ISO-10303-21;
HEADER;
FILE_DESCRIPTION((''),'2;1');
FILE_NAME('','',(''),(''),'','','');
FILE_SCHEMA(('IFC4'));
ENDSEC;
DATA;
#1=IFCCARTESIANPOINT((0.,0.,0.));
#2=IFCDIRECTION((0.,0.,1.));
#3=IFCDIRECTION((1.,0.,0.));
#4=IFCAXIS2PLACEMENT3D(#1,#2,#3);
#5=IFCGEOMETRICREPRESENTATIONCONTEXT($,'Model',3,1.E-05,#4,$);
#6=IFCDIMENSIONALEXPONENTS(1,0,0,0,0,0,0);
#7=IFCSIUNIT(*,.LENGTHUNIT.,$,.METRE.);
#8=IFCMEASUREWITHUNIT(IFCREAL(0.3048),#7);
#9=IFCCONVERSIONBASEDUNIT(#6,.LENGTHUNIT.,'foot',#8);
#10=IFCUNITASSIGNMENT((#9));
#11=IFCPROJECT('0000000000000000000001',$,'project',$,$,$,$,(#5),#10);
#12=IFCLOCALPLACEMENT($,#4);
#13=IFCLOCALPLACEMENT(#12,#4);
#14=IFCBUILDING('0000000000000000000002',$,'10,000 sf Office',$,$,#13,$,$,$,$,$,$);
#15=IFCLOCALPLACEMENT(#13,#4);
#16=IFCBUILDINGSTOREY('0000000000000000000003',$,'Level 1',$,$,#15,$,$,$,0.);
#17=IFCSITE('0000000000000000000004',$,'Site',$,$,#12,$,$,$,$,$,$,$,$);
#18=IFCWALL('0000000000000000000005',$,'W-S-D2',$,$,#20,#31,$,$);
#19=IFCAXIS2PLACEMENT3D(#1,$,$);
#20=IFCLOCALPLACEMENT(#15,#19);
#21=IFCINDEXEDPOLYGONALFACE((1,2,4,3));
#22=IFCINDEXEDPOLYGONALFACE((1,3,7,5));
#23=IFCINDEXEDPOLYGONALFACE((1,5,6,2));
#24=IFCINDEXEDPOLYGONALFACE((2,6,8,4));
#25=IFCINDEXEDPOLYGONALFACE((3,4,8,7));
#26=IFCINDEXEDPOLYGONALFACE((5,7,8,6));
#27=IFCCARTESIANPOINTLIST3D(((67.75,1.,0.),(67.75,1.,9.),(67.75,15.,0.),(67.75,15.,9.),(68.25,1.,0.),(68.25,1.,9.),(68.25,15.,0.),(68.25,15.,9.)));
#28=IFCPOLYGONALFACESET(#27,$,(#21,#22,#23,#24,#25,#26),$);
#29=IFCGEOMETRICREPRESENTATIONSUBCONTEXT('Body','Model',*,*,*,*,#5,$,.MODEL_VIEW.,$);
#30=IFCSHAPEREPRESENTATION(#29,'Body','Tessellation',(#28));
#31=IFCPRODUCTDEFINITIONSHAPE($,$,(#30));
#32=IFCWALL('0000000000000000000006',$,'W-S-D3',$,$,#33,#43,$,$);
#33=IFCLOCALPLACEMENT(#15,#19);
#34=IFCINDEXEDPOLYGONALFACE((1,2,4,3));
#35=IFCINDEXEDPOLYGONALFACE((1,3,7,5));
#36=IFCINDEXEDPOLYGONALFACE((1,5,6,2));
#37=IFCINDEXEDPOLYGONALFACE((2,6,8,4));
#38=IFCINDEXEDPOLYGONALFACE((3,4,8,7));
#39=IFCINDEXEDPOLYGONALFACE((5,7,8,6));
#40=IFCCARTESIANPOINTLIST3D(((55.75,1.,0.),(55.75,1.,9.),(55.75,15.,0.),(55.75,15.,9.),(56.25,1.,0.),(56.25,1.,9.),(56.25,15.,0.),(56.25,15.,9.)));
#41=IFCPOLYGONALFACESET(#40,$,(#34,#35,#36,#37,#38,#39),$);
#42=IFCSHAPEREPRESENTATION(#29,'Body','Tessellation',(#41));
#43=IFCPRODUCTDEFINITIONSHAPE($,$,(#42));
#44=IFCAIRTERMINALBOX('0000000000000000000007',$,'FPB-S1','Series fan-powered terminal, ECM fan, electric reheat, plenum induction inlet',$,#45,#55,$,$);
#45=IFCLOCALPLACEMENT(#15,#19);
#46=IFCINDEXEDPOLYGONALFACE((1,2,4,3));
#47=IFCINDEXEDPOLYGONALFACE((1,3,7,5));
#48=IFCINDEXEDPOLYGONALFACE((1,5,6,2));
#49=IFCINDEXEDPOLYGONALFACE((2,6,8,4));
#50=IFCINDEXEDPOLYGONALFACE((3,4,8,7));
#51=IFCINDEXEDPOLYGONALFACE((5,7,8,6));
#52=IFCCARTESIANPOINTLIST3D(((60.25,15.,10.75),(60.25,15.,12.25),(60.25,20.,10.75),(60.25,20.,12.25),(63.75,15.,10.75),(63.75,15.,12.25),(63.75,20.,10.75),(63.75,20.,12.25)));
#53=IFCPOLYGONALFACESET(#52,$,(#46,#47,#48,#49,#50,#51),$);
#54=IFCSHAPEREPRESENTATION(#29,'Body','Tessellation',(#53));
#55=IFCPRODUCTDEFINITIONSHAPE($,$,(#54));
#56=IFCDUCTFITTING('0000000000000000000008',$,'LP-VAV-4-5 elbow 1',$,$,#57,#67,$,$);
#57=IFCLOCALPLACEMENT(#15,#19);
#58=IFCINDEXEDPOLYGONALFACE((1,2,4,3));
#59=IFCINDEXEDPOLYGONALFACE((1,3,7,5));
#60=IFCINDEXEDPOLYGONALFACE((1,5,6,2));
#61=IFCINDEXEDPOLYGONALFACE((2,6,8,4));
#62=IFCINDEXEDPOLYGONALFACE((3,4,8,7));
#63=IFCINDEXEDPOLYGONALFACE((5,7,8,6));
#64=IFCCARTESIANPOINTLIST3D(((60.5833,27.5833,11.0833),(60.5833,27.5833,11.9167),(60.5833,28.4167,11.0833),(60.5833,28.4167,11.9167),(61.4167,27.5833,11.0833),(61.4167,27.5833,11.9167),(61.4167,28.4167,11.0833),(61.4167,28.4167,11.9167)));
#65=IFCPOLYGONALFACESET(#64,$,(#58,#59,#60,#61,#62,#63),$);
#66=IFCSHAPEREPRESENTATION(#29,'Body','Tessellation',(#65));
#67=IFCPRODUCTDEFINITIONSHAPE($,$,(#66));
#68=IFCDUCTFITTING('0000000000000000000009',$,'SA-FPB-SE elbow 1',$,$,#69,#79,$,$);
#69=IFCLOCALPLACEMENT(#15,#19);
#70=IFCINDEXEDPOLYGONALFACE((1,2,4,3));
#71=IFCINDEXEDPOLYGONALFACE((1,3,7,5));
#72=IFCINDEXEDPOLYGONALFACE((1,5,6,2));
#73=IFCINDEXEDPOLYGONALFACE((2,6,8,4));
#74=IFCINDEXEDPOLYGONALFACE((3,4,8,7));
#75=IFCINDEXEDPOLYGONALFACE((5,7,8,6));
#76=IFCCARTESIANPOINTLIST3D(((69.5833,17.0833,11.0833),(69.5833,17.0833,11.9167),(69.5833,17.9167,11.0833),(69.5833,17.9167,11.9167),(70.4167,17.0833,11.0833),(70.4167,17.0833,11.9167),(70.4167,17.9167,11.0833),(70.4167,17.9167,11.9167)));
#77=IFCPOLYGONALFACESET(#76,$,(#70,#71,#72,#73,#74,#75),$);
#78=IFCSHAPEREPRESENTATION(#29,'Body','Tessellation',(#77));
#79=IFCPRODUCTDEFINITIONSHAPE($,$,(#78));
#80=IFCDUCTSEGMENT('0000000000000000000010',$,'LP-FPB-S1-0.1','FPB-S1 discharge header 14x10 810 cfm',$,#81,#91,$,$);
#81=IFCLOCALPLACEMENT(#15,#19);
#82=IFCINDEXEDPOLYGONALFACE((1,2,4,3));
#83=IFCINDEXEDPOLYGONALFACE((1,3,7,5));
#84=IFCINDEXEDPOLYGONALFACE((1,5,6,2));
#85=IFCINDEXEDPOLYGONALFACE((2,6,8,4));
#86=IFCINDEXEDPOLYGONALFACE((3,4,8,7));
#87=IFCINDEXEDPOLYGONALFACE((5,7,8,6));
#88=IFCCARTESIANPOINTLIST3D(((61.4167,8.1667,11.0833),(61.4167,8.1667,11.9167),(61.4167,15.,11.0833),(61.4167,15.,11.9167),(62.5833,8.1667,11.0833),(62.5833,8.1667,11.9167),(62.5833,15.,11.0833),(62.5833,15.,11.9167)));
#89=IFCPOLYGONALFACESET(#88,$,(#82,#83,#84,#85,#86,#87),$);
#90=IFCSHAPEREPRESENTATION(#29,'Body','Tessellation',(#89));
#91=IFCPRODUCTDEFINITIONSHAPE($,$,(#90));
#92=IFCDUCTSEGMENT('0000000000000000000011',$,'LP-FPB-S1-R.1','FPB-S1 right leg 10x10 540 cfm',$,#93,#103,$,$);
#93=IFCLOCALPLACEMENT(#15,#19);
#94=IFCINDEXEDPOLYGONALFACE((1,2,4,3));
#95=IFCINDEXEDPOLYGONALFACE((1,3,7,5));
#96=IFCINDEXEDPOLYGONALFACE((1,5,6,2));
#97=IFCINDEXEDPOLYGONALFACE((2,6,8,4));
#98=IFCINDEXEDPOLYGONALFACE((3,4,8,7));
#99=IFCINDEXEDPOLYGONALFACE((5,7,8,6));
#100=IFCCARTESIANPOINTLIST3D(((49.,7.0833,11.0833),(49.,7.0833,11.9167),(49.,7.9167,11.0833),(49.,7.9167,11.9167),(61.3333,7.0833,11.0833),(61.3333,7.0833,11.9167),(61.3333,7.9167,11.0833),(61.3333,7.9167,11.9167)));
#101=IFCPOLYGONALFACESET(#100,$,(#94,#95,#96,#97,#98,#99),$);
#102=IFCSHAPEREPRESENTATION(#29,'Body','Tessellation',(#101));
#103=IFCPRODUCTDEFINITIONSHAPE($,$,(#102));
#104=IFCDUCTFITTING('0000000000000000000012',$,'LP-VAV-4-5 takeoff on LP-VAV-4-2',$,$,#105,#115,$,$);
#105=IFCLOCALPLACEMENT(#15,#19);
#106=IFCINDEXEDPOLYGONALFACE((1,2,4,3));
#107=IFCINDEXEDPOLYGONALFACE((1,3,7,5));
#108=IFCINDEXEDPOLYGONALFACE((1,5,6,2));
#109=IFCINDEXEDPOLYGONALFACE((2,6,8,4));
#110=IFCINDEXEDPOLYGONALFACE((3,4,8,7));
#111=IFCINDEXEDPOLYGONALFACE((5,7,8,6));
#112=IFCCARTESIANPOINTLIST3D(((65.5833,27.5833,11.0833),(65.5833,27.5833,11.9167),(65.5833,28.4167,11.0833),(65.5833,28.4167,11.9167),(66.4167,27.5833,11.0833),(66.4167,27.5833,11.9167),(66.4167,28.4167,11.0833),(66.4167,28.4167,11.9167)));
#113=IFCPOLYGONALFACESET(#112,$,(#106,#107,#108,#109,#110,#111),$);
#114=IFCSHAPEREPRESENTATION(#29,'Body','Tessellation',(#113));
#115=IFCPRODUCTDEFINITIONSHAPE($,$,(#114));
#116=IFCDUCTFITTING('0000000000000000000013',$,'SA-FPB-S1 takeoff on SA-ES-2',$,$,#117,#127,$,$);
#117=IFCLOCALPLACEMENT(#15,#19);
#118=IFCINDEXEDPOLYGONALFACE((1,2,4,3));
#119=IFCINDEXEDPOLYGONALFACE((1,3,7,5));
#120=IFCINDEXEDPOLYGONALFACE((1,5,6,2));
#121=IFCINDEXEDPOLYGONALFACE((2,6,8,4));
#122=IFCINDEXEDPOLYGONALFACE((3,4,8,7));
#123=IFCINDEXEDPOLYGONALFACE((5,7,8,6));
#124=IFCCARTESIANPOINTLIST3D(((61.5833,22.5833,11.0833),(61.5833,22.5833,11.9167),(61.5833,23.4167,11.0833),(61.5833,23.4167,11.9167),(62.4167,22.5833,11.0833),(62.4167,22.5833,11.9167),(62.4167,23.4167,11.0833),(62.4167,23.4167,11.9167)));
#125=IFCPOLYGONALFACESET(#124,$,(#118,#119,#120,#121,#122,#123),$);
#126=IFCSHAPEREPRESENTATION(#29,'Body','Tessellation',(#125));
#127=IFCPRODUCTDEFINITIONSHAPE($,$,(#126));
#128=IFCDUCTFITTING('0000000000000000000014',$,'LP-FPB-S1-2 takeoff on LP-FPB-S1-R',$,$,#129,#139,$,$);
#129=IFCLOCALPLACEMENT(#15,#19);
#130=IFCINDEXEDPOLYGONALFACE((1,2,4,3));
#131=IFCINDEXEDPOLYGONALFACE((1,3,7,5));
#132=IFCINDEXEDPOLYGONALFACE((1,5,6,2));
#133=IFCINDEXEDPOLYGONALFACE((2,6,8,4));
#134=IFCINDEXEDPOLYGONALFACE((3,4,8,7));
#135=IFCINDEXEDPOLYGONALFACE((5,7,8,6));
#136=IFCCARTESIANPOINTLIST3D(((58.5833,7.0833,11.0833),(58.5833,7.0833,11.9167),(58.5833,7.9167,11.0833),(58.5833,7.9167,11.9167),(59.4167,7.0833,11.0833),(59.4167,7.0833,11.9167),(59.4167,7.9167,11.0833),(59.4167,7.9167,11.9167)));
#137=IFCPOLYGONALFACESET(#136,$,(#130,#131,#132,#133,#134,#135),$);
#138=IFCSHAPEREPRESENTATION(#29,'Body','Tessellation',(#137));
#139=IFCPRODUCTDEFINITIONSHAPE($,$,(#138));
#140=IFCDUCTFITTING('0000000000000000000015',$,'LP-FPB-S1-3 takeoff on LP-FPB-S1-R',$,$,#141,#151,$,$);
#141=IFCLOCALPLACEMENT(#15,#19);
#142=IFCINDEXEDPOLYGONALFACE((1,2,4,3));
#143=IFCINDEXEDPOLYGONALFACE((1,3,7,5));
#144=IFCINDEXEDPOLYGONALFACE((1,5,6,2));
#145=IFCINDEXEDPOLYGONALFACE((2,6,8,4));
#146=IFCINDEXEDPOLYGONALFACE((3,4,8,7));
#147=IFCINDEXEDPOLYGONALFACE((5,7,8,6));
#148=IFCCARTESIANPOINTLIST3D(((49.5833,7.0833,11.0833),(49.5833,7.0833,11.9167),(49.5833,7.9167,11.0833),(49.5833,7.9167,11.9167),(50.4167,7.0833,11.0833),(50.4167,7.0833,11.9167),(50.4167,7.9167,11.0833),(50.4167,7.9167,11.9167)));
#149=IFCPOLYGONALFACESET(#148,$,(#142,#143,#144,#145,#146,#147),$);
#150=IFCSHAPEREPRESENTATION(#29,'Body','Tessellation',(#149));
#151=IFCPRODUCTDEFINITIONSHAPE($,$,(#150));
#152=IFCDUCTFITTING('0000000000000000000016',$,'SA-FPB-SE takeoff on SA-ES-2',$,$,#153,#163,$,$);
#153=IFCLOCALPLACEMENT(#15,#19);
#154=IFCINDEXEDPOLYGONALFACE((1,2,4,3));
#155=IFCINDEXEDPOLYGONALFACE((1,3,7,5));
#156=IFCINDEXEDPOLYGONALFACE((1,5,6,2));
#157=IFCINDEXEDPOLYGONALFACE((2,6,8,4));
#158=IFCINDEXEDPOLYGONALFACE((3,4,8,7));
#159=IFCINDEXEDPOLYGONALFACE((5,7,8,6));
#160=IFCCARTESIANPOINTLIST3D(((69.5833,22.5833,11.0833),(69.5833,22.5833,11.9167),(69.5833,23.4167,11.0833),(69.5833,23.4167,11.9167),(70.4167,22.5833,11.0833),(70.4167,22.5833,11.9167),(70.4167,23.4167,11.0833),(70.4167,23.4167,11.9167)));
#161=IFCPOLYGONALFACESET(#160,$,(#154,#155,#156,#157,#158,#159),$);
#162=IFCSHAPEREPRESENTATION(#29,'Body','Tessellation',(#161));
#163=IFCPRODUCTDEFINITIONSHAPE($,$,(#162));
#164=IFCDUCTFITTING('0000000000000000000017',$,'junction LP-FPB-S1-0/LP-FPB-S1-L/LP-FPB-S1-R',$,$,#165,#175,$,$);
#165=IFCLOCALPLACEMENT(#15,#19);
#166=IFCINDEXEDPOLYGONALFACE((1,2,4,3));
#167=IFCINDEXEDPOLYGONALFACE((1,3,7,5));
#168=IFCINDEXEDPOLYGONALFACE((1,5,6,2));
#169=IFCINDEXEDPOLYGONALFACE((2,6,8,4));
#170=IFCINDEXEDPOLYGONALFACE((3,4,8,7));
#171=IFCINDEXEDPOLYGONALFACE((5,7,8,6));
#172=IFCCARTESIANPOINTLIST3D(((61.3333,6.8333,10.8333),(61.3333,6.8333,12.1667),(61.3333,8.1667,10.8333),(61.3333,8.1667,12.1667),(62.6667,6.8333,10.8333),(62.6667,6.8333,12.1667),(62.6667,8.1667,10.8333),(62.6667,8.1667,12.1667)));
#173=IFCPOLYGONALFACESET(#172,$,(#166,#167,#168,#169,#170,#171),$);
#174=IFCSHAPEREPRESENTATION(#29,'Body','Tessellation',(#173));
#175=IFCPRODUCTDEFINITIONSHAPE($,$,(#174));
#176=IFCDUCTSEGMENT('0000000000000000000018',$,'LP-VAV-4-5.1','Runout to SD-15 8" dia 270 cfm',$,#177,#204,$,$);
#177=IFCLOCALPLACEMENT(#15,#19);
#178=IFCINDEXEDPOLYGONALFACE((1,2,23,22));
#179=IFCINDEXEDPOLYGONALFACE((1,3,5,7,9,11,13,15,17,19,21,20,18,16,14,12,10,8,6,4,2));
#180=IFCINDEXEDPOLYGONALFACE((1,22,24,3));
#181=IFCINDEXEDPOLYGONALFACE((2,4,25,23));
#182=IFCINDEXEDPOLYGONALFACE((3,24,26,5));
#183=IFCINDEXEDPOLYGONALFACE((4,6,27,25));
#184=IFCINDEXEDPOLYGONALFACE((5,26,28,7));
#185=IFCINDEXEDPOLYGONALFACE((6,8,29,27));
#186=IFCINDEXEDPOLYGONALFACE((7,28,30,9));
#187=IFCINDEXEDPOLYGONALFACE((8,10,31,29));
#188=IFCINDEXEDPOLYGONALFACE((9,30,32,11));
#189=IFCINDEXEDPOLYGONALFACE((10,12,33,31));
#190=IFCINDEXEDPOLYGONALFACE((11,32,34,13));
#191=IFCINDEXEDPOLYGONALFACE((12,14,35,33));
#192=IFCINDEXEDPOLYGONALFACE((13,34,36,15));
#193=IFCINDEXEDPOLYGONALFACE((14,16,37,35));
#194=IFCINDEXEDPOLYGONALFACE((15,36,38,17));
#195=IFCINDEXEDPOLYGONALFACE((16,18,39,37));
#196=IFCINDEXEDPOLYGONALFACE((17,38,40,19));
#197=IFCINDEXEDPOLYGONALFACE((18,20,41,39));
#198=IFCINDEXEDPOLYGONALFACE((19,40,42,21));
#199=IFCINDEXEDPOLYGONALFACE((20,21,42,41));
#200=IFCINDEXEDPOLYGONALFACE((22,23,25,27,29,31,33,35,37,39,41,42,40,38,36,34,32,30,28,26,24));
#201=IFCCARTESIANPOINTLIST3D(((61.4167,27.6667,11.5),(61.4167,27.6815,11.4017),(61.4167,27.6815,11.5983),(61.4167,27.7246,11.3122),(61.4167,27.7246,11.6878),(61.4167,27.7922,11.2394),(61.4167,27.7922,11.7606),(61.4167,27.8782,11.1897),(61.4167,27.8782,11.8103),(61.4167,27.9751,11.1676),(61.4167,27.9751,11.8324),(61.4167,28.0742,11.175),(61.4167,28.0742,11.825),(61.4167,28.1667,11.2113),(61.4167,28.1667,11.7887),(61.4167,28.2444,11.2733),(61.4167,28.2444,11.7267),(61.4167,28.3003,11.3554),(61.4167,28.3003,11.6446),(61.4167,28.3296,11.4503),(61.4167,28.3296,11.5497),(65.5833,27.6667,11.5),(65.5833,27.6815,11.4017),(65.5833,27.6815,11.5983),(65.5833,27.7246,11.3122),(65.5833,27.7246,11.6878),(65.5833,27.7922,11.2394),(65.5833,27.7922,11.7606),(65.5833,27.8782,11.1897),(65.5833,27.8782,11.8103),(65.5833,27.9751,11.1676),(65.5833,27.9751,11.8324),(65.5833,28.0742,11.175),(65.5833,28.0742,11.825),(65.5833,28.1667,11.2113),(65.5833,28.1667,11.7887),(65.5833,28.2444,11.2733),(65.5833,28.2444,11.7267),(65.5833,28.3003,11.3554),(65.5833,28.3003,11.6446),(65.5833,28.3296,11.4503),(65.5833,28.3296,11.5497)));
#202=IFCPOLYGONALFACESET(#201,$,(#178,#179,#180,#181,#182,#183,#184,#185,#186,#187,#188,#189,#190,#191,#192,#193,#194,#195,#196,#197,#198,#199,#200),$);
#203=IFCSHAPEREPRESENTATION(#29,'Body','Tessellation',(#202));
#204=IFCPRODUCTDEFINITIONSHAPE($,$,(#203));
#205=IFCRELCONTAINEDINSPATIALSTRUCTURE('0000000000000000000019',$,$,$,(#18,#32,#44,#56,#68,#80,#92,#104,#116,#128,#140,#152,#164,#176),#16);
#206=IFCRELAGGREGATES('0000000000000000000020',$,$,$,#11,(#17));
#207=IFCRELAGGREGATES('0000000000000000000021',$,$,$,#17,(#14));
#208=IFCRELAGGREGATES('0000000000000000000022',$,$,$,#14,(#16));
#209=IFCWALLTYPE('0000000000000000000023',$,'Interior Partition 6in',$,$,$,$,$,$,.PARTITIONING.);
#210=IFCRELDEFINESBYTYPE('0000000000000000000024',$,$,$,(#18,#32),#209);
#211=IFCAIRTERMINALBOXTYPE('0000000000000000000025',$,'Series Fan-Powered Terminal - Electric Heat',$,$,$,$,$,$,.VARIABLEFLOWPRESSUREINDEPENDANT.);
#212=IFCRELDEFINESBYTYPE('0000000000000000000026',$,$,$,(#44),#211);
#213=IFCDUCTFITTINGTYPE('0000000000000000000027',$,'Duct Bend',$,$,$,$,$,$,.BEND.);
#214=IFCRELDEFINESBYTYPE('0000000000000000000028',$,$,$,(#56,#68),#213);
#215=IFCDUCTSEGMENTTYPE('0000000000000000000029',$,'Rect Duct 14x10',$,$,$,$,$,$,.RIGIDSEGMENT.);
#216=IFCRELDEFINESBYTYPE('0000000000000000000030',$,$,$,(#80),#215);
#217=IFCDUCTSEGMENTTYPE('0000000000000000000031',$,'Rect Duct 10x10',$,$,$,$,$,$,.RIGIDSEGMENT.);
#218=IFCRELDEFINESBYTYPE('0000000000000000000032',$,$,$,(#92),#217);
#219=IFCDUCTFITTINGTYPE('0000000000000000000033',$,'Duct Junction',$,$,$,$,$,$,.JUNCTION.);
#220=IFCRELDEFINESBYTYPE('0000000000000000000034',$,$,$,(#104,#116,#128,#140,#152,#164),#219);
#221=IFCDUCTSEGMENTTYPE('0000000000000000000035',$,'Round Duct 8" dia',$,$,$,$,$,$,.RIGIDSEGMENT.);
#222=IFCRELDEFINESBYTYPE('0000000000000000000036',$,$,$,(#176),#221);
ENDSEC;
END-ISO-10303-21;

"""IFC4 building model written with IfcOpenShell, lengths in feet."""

from ifc_helpers import new_model, entity, si_unit, converted_unit, frame, origin_with_axes, place, context, subcontext, project, spatial, rectangle, circle, extrude, type_object, element, save


model = new_model("IFC4")

# Units and contexts
model_context = context("Model", 3, precision=1e-05, world=origin_with_axes())
body_context = subcontext(model_context, "Body", "Model", "MODEL_VIEW")
ifc_project = project(units=[converted_unit("LENGTHUNIT", "foot", entity("IfcReal", 0.3048), si_unit("LENGTHUNIT", "METRE"), dimensions=[1, 0, 0, 0, 0, 0, 0])], contexts=[model_context])

# Site, building, storey
site_placement = place(None, origin_with_axes())
site = spatial("IfcSite", under=ifc_project, at=site_placement, Name="Site")
building_placement = place(site_placement, origin_with_axes())
building = spatial("IfcBuilding", under=site, at=building_placement, Name="10,000 sf Office")
storey_placement = place(building_placement, origin_with_axes())
storey = spatial("IfcBuildingStorey", under=building, at=storey_placement, Name="Level 1", Elevation=0.0)

# Walls
wall_type = type_object("IfcWallType", Name="Interior Partition 6in", PredefinedType="PARTITIONING")
for number, where, z_axis, x_axis, name in (
    (1, (68.0, 8.0, 0.0), (0.0, 0.0, 1.0), (0.0, 1.0, 0.0), "W-S-D2"),
    (2, (56.0, 8.0, 0.0), (0.0, 0.0, 1.0), (0.0, 1.0, 0.0), "W-S-D3"),
):
    element("IfcWall", number, at=place(storey_placement, frame(where, z_axis=z_axis, x_axis=x_axis)), inside=storey, type_object=wall_type, Name=name, context=body_context, shape_type="SweptSolid", body=[
        extrude(rectangle(XDim=14.0, YDim=0.5), None, (0.0, 0.0, 1.0), 9.0),
    ])

# Air terminal box
air_terminal_box_type = type_object("IfcAirTerminalBoxType", Name="Series Fan-Powered Terminal - Electric Heat", PredefinedType="VARIABLEFLOWPRESSUREINDEPENDANT")
air_terminal_box_placement = place(storey_placement, frame((62.0, 17.5, 10.75), z_axis=(0.0, 0.0, 1.0), x_axis=(0.0, -1.0, 0.0)))
element("IfcAirTerminalBox", 3, at=air_terminal_box_placement, inside=storey, type_object=air_terminal_box_type, Name="FPB-S1", Description="Series fan-powered terminal, ECM fan, electric reheat, plenum induction inlet", context=body_context, shape_type="SweptSolid", body=[
    extrude(rectangle(XDim=5.0, YDim=3.5), None, (0.0, 0.0, 1.0), 1.5),
])

# Duct fittings
duct_fitting_type_1 = type_object("IfcDuctFittingType", Name="Duct Bend", PredefinedType="BEND")
for number, where, z_axis, x_axis, name in (
    (4, (61.0, 28.0, 11.0833), (0.0, 0.0, 1.0), (1.0, 0.0, 0.0), "LP-VAV-4-5 elbow 1"),
    (5, (70.0, 17.5, 11.0833), (0.0, 0.0, 1.0), (1.0, 0.0, 0.0), "SA-FPB-SE elbow 1"),
):
    element("IfcDuctFitting", number, at=place(storey_placement, frame(where, z_axis=z_axis, x_axis=x_axis)), inside=storey, type_object=duct_fitting_type_1, Name=name, context=body_context, shape_type="SweptSolid", body=[
        extrude(rectangle(XDim=0.8333, YDim=0.8333), None, (0.0, 0.0, 1.0), 0.8333),
    ])

# Duct segments
duct_segment_type_1 = type_object("IfcDuctSegmentType", Name="Rect Duct 14x10", PredefinedType="RIGIDSEGMENT")
duct_segment_1_placement = place(storey_placement, frame((62.0, 15.0, 11.5), z_axis=(0.0, -1.0, 0.0), x_axis=(1.0, 0.0, 0.0)))
element("IfcDuctSegment", 6, at=duct_segment_1_placement, inside=storey, type_object=duct_segment_type_1, Name="LP-FPB-S1-0.1", Description="FPB-S1 discharge header 14x10 810 cfm", context=body_context, shape_type="SweptSolid", body=[
    extrude(rectangle(XDim=1.1667, YDim=0.8333), None, (0.0, 0.0, 1.0), 6.8333),
])
duct_segment_type_2 = type_object("IfcDuctSegmentType", Name="Rect Duct 10x10", PredefinedType="RIGIDSEGMENT")
duct_segment_2_placement = place(storey_placement, frame((61.3333, 7.5, 11.5), z_axis=(-1.0, 0.0, 0.0), x_axis=(0.0, -1.0, 0.0)))
element("IfcDuctSegment", 7, at=duct_segment_2_placement, inside=storey, type_object=duct_segment_type_2, Name="LP-FPB-S1-R.1", Description="FPB-S1 right leg 10x10 540 cfm", context=body_context, shape_type="SweptSolid", body=[
    extrude(rectangle(XDim=0.8333, YDim=0.8333), None, (0.0, 0.0, 1.0), 12.3333),
])

# Duct fittings
duct_fitting_type_2 = type_object("IfcDuctFittingType", Name="Duct Junction", PredefinedType="JUNCTION")
for number, where, z_axis, x_axis, name in (
    (8, (66.0, 28.0, 11.0833), (0.0, 0.0, 1.0), (1.0, 0.0, 0.0), "LP-VAV-4-5 takeoff on LP-VAV-4-2"),
    (9, (62.0, 23.0, 11.0833), (0.0, 0.0, 1.0), (1.0, 0.0, 0.0), "SA-FPB-S1 takeoff on SA-ES-2"),
    (10, (59.0, 7.5, 11.0833), (0.0, 0.0, 1.0), (1.0, 0.0, 0.0), "LP-FPB-S1-2 takeoff on LP-FPB-S1-R"),
    (11, (50.0, 7.5, 11.0833), (0.0, 0.0, 1.0), (1.0, 0.0, 0.0), "LP-FPB-S1-3 takeoff on LP-FPB-S1-R"),
    (12, (70.0, 23.0, 11.0833), (0.0, 0.0, 1.0), (1.0, 0.0, 0.0), "SA-FPB-SE takeoff on SA-ES-2"),
):
    element("IfcDuctFitting", number, at=place(storey_placement, frame(where, z_axis=z_axis, x_axis=x_axis)), inside=storey, type_object=duct_fitting_type_2, Name=name, context=body_context, shape_type="SweptSolid", body=[
        extrude(rectangle(XDim=0.8333, YDim=0.8333), None, (0.0, 0.0, 1.0), 0.8333),
    ])
duct_fitting_placement = place(storey_placement, frame((62.0, 7.5, 10.8333), z_axis=(0.0, 0.0, 1.0), x_axis=(1.0, 0.0, 0.0)))
element("IfcDuctFitting", 13, at=duct_fitting_placement, inside=storey, type_object=duct_fitting_type_2, Name="junction LP-FPB-S1-0/LP-FPB-S1-L/LP-FPB-S1-R", context=body_context, shape_type="SweptSolid", body=[
    extrude(rectangle(XDim=1.3333, YDim=1.3333), None, (0.0, 0.0, 1.0), 1.3333),
])

# Duct segment
duct_segment_type_3 = type_object("IfcDuctSegmentType", Name="Round Duct 8\" dia", PredefinedType="RIGIDSEGMENT")
duct_segment_3_placement = place(storey_placement, frame((65.5833, 28.0, 11.5), z_axis=(-1.0, 0.0, 0.0), x_axis=(0.0, -1.0, 0.0)))
element("IfcDuctSegment", 14, at=duct_segment_3_placement, inside=storey, type_object=duct_segment_type_3, Name="LP-VAV-4-5.1", Description="Runout to SD-15 8\" dia 270 cfm", context=body_context, shape_type="SweptSolid", body=[
    extrude(circle(Radius=0.3333), None, (0.0, 0.0, 1.0), 4.1667),
])

save(model, "model.ifc")
